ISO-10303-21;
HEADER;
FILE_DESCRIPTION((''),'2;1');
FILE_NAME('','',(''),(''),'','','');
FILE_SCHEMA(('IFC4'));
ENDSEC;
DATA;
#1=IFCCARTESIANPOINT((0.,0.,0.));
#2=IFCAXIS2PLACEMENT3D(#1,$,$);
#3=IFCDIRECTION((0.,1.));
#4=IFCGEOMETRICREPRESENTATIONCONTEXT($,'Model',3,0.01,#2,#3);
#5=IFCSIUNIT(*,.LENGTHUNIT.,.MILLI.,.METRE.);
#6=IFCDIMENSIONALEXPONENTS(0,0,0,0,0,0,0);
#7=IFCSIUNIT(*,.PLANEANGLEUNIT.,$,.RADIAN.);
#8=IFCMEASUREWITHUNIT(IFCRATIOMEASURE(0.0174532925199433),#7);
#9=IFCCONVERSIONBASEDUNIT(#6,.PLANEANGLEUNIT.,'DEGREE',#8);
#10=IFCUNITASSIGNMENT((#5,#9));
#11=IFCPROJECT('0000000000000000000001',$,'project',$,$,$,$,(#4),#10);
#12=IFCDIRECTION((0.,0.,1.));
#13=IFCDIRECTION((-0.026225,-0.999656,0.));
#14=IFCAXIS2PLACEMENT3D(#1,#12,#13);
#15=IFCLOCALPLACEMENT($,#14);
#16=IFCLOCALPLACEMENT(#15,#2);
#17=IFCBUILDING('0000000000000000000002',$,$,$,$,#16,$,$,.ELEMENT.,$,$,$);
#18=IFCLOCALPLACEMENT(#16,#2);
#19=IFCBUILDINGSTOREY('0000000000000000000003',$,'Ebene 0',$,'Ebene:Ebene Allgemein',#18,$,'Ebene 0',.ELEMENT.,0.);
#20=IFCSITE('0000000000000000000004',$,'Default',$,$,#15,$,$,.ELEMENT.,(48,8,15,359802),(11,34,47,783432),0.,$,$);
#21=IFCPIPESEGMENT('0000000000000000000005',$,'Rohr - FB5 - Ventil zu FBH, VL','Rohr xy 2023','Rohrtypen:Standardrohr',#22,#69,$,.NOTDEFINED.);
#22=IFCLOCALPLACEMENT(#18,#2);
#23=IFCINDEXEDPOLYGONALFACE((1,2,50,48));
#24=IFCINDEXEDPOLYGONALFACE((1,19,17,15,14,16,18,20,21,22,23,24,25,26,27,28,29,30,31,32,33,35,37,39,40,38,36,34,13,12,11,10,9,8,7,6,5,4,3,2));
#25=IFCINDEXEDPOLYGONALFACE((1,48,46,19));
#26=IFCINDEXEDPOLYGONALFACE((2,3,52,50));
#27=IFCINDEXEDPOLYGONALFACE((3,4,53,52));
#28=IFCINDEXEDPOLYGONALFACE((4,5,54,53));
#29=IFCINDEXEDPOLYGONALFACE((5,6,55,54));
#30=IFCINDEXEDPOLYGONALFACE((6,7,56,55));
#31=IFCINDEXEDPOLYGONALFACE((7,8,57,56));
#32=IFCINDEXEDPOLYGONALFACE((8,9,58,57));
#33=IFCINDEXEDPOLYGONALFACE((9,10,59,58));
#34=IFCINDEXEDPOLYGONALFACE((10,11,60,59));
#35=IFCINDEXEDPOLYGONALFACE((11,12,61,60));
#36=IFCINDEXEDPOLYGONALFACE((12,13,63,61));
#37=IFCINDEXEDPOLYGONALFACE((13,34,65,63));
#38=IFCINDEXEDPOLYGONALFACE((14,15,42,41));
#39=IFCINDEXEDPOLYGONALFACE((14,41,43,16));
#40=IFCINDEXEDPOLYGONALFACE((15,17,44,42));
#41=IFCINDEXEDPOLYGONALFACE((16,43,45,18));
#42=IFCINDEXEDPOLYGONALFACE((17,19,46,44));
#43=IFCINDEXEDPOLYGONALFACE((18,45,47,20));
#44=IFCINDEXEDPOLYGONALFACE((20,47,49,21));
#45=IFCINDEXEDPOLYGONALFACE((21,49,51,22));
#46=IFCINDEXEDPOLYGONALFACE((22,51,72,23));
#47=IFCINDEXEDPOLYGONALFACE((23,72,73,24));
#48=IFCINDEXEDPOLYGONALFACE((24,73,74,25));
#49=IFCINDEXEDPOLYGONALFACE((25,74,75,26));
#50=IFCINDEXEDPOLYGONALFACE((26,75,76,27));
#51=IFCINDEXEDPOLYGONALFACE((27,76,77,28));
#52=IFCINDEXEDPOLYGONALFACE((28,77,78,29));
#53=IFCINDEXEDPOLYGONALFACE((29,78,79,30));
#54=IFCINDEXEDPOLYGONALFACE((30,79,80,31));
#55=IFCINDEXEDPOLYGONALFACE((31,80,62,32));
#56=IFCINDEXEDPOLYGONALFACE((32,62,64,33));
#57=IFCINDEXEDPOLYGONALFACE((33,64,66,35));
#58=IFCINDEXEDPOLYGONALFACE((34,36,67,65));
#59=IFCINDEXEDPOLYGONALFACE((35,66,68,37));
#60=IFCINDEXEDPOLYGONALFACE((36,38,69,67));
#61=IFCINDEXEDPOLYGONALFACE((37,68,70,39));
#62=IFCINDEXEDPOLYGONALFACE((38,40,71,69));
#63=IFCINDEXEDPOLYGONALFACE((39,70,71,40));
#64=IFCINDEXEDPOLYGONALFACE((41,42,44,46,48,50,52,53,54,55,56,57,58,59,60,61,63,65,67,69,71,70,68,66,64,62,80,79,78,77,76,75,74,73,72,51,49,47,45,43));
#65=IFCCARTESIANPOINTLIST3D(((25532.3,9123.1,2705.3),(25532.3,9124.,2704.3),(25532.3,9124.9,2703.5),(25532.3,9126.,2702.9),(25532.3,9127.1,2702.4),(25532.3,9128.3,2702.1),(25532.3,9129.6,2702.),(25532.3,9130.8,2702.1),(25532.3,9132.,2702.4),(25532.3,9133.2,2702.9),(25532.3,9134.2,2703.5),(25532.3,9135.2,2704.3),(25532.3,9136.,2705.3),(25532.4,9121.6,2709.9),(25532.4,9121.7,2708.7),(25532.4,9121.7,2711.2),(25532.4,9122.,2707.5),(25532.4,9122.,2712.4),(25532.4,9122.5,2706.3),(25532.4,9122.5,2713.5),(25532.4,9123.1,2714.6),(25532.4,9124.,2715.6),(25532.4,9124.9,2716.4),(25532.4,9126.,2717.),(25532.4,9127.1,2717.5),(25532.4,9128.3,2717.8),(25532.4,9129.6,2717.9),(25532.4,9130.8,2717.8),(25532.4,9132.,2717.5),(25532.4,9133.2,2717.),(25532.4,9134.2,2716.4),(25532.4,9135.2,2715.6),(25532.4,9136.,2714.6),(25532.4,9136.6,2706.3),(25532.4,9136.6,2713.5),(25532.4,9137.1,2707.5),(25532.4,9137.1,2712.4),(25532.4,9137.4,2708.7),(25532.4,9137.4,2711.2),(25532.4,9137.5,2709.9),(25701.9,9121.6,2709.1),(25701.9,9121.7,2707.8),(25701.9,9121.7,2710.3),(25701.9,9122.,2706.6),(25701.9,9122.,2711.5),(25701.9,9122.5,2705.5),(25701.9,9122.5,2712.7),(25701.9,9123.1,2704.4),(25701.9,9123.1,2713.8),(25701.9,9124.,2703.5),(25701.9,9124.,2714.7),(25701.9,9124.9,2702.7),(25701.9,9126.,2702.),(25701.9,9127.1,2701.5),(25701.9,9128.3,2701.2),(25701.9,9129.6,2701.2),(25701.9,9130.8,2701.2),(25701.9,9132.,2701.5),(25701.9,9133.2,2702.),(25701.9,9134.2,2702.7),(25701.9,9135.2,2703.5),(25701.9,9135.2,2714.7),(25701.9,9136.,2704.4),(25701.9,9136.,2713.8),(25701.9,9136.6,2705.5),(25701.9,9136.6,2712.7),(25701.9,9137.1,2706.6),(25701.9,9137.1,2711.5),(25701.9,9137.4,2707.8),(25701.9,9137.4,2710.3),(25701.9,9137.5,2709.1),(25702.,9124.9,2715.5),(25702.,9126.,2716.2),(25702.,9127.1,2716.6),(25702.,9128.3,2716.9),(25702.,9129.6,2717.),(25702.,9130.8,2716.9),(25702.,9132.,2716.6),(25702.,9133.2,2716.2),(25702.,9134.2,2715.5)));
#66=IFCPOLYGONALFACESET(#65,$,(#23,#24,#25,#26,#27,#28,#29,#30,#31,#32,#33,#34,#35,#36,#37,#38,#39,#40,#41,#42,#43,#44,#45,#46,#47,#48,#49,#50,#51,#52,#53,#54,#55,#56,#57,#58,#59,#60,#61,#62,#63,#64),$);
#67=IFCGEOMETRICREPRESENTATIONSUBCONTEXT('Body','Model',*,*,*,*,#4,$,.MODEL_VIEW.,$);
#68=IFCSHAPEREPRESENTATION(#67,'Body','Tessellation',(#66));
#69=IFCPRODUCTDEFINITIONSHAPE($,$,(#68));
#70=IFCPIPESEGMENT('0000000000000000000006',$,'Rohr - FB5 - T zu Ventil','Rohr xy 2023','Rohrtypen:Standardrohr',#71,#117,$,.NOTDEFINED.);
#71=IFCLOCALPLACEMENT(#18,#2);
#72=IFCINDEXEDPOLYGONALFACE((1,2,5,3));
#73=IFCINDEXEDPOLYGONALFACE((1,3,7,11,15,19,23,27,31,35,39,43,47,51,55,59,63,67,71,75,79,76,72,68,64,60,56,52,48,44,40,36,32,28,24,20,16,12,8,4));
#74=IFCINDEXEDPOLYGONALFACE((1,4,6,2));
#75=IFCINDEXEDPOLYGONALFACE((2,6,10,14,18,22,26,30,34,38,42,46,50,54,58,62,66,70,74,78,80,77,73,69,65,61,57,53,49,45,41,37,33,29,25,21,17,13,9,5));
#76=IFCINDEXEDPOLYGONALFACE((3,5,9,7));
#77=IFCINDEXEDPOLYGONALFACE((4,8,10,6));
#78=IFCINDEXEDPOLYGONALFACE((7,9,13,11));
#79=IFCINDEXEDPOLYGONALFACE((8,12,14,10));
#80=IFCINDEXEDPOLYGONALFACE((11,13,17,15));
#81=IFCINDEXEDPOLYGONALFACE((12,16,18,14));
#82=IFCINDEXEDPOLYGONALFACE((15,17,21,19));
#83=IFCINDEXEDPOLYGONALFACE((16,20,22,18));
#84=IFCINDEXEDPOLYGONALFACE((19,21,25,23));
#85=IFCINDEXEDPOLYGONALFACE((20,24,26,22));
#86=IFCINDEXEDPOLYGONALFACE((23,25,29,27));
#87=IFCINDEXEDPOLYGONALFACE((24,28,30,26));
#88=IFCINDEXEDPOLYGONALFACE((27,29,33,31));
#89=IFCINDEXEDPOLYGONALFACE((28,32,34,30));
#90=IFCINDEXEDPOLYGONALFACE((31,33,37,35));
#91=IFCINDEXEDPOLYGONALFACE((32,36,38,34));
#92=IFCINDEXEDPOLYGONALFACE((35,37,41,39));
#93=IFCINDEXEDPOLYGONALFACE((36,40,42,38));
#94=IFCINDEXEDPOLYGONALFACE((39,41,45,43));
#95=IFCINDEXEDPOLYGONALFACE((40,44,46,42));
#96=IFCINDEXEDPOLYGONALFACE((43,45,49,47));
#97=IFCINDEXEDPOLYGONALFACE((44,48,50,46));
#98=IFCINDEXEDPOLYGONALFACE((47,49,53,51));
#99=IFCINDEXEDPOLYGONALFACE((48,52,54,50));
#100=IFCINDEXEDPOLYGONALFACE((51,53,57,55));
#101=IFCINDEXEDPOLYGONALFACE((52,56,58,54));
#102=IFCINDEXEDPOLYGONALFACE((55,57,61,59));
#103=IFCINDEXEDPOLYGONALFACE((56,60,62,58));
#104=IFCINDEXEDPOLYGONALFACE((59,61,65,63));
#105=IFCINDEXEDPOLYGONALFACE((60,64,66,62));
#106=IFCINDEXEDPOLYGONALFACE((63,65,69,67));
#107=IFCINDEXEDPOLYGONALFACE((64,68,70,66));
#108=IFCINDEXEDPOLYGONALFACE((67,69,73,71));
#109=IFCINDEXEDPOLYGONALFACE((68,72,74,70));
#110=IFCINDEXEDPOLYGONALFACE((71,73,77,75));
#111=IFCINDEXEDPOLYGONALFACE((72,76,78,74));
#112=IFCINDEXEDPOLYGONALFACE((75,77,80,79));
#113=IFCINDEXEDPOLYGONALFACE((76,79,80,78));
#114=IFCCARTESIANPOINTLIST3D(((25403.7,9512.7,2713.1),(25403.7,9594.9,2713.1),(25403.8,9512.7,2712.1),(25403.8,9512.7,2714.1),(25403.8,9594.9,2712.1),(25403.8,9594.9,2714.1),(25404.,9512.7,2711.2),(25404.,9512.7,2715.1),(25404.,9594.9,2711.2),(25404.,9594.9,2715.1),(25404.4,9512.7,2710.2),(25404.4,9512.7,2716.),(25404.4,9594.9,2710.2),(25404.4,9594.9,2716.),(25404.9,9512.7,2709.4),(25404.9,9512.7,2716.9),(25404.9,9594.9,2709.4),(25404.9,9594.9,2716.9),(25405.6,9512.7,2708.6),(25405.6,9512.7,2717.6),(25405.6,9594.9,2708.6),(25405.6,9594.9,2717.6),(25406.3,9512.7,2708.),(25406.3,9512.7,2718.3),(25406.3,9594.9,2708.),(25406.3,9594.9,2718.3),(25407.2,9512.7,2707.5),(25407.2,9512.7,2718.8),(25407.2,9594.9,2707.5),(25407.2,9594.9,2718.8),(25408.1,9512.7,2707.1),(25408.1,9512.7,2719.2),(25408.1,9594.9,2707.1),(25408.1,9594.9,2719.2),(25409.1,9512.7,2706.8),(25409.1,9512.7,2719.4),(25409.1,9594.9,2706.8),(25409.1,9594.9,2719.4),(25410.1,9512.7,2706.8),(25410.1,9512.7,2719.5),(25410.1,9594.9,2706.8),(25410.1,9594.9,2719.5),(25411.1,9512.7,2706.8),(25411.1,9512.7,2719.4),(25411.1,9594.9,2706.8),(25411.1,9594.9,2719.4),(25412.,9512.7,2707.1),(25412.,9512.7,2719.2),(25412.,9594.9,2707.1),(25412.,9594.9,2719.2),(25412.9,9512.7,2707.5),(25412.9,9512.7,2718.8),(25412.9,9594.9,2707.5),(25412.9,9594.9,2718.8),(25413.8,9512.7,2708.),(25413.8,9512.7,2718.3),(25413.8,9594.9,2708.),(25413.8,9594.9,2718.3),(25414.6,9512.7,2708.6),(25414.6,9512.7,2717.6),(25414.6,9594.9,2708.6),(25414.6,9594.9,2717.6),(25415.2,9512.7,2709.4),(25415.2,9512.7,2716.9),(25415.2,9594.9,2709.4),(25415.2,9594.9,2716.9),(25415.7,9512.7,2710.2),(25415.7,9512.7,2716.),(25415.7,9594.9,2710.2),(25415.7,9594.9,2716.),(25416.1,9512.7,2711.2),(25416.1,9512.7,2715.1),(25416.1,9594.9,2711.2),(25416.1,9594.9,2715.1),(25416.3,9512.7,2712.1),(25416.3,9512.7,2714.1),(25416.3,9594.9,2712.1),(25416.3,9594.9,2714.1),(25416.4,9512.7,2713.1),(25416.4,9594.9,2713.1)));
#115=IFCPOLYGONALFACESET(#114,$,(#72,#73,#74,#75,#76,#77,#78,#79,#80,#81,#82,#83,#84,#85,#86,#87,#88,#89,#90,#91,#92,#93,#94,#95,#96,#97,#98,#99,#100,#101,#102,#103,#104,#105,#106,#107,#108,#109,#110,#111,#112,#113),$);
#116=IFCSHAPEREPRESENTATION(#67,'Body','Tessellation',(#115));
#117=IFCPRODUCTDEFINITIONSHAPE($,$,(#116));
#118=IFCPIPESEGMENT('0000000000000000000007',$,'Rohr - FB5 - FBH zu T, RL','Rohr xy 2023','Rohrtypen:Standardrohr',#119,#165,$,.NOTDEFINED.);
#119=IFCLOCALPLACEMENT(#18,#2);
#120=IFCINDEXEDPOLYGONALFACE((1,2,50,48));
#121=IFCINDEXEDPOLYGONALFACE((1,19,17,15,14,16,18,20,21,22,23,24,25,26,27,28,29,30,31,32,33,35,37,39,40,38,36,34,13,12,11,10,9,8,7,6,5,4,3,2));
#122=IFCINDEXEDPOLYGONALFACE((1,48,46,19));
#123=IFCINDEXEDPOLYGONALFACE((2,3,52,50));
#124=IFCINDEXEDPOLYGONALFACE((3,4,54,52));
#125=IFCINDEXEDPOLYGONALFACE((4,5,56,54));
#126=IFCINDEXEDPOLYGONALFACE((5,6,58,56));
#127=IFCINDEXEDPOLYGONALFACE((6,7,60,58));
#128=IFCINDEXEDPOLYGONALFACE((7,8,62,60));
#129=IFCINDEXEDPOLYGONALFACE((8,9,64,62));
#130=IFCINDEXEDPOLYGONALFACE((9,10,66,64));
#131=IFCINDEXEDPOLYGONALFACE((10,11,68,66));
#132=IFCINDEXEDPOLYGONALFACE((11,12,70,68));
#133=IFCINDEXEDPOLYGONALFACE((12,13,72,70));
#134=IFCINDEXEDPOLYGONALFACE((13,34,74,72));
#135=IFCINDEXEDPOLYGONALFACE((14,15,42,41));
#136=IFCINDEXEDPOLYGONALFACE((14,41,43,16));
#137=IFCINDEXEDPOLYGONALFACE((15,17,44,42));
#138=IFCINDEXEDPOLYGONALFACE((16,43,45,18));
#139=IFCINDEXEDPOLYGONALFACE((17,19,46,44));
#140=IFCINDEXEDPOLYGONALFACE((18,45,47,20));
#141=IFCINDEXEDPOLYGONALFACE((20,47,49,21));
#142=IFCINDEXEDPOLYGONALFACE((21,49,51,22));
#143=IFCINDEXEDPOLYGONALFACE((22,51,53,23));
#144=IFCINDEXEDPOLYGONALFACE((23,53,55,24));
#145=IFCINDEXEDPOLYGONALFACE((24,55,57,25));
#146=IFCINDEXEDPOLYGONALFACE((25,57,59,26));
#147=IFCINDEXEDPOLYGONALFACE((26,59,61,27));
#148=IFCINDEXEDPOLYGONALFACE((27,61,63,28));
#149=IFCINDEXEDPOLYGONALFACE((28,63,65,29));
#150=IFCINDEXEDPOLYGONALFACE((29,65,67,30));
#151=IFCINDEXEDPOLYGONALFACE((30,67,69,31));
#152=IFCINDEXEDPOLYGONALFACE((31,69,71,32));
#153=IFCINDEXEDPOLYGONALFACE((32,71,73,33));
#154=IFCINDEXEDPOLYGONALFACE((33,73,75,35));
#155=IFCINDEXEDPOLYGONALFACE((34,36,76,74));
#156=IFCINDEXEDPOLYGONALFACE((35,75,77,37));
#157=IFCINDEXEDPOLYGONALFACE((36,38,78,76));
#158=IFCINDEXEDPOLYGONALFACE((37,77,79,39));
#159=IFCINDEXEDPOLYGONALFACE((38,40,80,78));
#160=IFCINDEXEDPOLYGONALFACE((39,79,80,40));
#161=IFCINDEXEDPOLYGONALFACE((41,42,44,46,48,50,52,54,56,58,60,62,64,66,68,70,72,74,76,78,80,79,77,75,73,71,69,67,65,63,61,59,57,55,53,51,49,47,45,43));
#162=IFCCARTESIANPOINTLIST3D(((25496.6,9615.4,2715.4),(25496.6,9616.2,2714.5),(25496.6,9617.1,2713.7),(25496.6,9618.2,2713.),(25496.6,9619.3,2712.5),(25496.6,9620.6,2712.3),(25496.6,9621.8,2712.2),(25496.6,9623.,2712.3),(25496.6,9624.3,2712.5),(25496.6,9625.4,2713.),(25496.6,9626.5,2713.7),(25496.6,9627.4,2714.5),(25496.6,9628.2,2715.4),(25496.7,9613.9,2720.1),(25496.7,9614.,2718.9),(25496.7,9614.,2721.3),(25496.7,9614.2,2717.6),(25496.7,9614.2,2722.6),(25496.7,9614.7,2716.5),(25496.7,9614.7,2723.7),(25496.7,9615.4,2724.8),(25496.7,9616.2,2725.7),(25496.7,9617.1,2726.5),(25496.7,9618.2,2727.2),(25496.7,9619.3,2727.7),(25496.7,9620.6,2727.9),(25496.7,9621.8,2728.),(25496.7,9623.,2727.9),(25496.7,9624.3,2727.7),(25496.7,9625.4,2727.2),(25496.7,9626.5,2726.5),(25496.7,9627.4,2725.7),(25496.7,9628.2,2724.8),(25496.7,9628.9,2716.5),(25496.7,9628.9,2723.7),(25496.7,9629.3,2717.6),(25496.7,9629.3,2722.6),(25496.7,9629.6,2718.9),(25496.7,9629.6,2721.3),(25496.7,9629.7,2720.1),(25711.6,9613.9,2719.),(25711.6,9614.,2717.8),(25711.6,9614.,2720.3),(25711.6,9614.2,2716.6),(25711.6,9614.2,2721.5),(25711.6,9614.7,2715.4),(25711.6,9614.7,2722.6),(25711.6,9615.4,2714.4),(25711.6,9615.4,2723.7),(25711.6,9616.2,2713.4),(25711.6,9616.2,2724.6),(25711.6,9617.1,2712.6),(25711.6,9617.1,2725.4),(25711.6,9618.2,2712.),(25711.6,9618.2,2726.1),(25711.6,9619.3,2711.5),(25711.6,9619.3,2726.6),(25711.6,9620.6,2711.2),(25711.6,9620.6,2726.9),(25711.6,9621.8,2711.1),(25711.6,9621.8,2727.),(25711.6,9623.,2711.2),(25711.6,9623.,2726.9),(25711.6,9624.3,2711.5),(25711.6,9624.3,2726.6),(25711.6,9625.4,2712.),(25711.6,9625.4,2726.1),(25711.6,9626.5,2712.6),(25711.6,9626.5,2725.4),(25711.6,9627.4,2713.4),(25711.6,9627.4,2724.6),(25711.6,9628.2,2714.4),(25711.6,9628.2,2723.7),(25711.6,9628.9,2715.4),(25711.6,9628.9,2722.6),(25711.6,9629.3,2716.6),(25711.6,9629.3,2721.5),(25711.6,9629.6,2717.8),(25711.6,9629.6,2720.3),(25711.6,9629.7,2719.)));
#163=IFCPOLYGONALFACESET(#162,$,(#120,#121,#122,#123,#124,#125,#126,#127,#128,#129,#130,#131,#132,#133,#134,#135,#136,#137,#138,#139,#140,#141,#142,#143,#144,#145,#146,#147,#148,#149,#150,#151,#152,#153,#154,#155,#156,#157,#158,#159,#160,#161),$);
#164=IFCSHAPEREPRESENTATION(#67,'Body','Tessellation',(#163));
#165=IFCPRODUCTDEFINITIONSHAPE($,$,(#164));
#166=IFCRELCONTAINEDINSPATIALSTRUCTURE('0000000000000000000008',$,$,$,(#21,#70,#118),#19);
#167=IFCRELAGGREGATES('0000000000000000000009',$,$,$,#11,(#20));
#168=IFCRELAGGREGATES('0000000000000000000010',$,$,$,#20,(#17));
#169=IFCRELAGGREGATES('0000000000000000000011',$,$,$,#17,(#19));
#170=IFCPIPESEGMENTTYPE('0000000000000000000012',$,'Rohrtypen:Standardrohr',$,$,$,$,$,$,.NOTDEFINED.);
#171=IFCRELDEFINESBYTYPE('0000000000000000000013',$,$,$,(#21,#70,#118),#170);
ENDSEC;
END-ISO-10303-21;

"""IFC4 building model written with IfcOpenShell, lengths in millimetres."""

from ifc_helpers import new_model, entity, si_unit, converted_unit, direction, frame, origin, place, context, subcontext, project, spatial, indexed_curve, outline, extrude, type_object, element, save


model = new_model("IFC4")

# Units and contexts
model_context = context("Model", 3, precision=0.01, world=origin(), true_north=direction((0.0, 1.0)))
body_context = subcontext(model_context, "Body", "Model", "MODEL_VIEW")
ifc_project = project(units=[si_unit("LENGTHUNIT", "METRE", prefix="MILLI"), converted_unit("PLANEANGLEUNIT", "DEGREE", entity("IfcRatioMeasure", 0.0174532925199433), si_unit("PLANEANGLEUNIT", "RADIAN"), dimensions=[0, 0, 0, 0, 0, 0, 0])], contexts=[model_context])

# Site, building, storey
site_placement = place(None, frame((0.0, 0.0, 0.0), z_axis=(0.0, 0.0, 1.0), x_axis=(-0.026225, -0.999656, 0.0)))
site = spatial("IfcSite", under=ifc_project, at=site_placement, Name="Default", CompositionType="ELEMENT", RefLatitude=(48, 8, 15, 359802), RefLongitude=(11, 34, 47, 783432), RefElevation=0.0)
building_placement = place(site_placement, origin())
building = spatial("IfcBuilding", under=site, at=building_placement, CompositionType="ELEMENT")
storey_placement = place(building_placement, origin())
storey = spatial("IfcBuildingStorey", under=building, at=storey_placement, Name="Ebene 0", ObjectType="Ebene:Ebene Allgemein", LongName="Ebene 0", CompositionType="ELEMENT", Elevation=0.0)

# Pipe segments
pipe_segment_type = type_object("IfcPipeSegmentType", Name="Rohrtypen:Standardrohr", PredefinedType="NOTDEFINED")
pipe_segment_1_placement = place(storey_placement, origin())
element("IfcPipeSegment", 1, at=pipe_segment_1_placement, inside=storey, type_object=pipe_segment_type, Name="Rohr - FB5 - Ventil zu FBH, VL", Description="Rohr xy 2023", ObjectType="Rohrtypen:Standardrohr", PredefinedType="NOTDEFINED", context=body_context, shape_type="SweptSolid", body=[
    extrude(outline(indexed_curve([(7.9, 0.0), (7.8, 1.2), (7.6, 2.5), (7.1, 3.6), (6.4, 4.7), (5.6, 5.6), (4.7, 6.4), (3.6, 7.1), (2.5, 7.6), (1.2, 7.8), (0.0, 7.9), (-1.2, 7.8), (-2.5, 7.6), (-3.6, 7.1), (-4.7, 6.4), (-5.6, 5.6), (-6.4, 4.7), (-7.1, 3.6), (-7.6, 2.5), (-7.8, 1.2), (-7.9, 0.0), (-7.8, -1.2), (-7.6, -2.5), (-7.1, -3.6), (-6.4, -4.7), (-5.6, -5.6), (-4.7, -6.4), (-3.6, -7.1), (-2.5, -7.6), (-1.2, -7.8), (0.0, -7.9), (1.2, -7.8), (2.5, -7.6), (3.6, -7.1), (4.7, -6.4), (5.6, -5.6), (6.4, -4.7), (7.1, -3.6), (7.6, -2.5), (7.8, -1.2), (7.9, 0.0)], self_intersect=False)), frame((25532.4, 9129.6, 2709.9), z_axis=(0.999988, 0.0, -0.005), x_axis=(0.0, 1.0, 0.0)), (0.0, 0.0, 1.0), 169.5),
])
pipe_segment_2_placement = place(storey_placement, origin())
element("IfcPipeSegment", 2, at=pipe_segment_2_placement, inside=storey, type_object=pipe_segment_type, Name="Rohr - FB5 - T zu Ventil", Description="Rohr xy 2023", ObjectType="Rohrtypen:Standardrohr", PredefinedType="NOTDEFINED", context=body_context, shape_type="SweptSolid", body=[
    extrude(outline(indexed_curve([(6.3, 0.0), (6.3, 1.0), (6.0, 2.0), (5.7, 2.9), (5.1, 3.7), (4.5, 4.5), (3.7, 5.1), (2.9, 5.7), (2.0, 6.0), (1.0, 6.3), (0.0, 6.4), (-1.0, 6.3), (-2.0, 6.0), (-2.9, 5.7), (-3.7, 5.1), (-4.5, 4.5), (-5.1, 3.7), (-5.7, 2.9), (-6.0, 2.0), (-6.3, 1.0), (-6.3, 0.0), (-6.3, -1.0), (-6.0, -2.0), (-5.7, -2.9), (-5.1, -3.7), (-4.5, -4.5), (-3.7, -5.1), (-2.9, -5.7), (-2.0, -6.0), (-1.0, -6.3), (0.0, -6.4), (1.0, -6.3), (2.0, -6.0), (2.9, -5.7), (3.7, -5.1), (4.5, -4.5), (5.1, -3.7), (5.7, -2.9), (6.0, -2.0), (6.3, -1.0), (6.3, 0.0)], self_intersect=False)), frame((25410.1, 9512.7, 2713.1), z_axis=(0.0, 1.0, 0.0), x_axis=(-1.0, 0.0, 0.0)), (0.0, 0.0, 1.0), 82.2),
])
pipe_segment_3_placement = place(storey_placement, origin())
element("IfcPipeSegment", 3, at=pipe_segment_3_placement, inside=storey, type_object=pipe_segment_type, Name="Rohr - FB5 - FBH zu T, RL", Description="Rohr xy 2023", ObjectType="Rohrtypen:Standardrohr", PredefinedType="NOTDEFINED", context=body_context, shape_type="SweptSolid", body=[
    extrude(outline(indexed_curve([(7.9, 0.0), (7.8, 1.2), (7.6, 2.5), (7.1, 3.6), (6.4, 4.7), (5.6, 5.6), (4.7, 6.4), (3.6, 7.1), (2.5, 7.6), (1.2, 7.8), (0.0, 7.9), (-1.2, 7.8), (-2.5, 7.6), (-3.6, 7.1), (-4.7, 6.4), (-5.6, 5.6), (-6.4, 4.7), (-7.1, 3.6), (-7.6, 2.5), (-7.8, 1.2), (-7.9, 0.0), (-7.8, -1.2), (-7.6, -2.5), (-7.1, -3.6), (-6.4, -4.7), (-5.6, -5.6), (-4.7, -6.4), (-3.6, -7.1), (-2.5, -7.6), (-1.2, -7.8), (0.0, -7.9), (1.2, -7.8), (2.5, -7.6), (3.6, -7.1), (4.7, -6.4), (5.6, -5.6), (6.4, -4.7), (7.1, -3.6), (7.6, -2.5), (7.8, -1.2), (7.9, 0.0)], self_intersect=False)), frame((25711.6, 9621.8, 2719.0), z_axis=(-0.999988, 0.0, 0.005), x_axis=(0.0, 1.0, 0.0)), (0.0, 0.0, 1.0), 214.9),
])

save(model, "model.ifc")
